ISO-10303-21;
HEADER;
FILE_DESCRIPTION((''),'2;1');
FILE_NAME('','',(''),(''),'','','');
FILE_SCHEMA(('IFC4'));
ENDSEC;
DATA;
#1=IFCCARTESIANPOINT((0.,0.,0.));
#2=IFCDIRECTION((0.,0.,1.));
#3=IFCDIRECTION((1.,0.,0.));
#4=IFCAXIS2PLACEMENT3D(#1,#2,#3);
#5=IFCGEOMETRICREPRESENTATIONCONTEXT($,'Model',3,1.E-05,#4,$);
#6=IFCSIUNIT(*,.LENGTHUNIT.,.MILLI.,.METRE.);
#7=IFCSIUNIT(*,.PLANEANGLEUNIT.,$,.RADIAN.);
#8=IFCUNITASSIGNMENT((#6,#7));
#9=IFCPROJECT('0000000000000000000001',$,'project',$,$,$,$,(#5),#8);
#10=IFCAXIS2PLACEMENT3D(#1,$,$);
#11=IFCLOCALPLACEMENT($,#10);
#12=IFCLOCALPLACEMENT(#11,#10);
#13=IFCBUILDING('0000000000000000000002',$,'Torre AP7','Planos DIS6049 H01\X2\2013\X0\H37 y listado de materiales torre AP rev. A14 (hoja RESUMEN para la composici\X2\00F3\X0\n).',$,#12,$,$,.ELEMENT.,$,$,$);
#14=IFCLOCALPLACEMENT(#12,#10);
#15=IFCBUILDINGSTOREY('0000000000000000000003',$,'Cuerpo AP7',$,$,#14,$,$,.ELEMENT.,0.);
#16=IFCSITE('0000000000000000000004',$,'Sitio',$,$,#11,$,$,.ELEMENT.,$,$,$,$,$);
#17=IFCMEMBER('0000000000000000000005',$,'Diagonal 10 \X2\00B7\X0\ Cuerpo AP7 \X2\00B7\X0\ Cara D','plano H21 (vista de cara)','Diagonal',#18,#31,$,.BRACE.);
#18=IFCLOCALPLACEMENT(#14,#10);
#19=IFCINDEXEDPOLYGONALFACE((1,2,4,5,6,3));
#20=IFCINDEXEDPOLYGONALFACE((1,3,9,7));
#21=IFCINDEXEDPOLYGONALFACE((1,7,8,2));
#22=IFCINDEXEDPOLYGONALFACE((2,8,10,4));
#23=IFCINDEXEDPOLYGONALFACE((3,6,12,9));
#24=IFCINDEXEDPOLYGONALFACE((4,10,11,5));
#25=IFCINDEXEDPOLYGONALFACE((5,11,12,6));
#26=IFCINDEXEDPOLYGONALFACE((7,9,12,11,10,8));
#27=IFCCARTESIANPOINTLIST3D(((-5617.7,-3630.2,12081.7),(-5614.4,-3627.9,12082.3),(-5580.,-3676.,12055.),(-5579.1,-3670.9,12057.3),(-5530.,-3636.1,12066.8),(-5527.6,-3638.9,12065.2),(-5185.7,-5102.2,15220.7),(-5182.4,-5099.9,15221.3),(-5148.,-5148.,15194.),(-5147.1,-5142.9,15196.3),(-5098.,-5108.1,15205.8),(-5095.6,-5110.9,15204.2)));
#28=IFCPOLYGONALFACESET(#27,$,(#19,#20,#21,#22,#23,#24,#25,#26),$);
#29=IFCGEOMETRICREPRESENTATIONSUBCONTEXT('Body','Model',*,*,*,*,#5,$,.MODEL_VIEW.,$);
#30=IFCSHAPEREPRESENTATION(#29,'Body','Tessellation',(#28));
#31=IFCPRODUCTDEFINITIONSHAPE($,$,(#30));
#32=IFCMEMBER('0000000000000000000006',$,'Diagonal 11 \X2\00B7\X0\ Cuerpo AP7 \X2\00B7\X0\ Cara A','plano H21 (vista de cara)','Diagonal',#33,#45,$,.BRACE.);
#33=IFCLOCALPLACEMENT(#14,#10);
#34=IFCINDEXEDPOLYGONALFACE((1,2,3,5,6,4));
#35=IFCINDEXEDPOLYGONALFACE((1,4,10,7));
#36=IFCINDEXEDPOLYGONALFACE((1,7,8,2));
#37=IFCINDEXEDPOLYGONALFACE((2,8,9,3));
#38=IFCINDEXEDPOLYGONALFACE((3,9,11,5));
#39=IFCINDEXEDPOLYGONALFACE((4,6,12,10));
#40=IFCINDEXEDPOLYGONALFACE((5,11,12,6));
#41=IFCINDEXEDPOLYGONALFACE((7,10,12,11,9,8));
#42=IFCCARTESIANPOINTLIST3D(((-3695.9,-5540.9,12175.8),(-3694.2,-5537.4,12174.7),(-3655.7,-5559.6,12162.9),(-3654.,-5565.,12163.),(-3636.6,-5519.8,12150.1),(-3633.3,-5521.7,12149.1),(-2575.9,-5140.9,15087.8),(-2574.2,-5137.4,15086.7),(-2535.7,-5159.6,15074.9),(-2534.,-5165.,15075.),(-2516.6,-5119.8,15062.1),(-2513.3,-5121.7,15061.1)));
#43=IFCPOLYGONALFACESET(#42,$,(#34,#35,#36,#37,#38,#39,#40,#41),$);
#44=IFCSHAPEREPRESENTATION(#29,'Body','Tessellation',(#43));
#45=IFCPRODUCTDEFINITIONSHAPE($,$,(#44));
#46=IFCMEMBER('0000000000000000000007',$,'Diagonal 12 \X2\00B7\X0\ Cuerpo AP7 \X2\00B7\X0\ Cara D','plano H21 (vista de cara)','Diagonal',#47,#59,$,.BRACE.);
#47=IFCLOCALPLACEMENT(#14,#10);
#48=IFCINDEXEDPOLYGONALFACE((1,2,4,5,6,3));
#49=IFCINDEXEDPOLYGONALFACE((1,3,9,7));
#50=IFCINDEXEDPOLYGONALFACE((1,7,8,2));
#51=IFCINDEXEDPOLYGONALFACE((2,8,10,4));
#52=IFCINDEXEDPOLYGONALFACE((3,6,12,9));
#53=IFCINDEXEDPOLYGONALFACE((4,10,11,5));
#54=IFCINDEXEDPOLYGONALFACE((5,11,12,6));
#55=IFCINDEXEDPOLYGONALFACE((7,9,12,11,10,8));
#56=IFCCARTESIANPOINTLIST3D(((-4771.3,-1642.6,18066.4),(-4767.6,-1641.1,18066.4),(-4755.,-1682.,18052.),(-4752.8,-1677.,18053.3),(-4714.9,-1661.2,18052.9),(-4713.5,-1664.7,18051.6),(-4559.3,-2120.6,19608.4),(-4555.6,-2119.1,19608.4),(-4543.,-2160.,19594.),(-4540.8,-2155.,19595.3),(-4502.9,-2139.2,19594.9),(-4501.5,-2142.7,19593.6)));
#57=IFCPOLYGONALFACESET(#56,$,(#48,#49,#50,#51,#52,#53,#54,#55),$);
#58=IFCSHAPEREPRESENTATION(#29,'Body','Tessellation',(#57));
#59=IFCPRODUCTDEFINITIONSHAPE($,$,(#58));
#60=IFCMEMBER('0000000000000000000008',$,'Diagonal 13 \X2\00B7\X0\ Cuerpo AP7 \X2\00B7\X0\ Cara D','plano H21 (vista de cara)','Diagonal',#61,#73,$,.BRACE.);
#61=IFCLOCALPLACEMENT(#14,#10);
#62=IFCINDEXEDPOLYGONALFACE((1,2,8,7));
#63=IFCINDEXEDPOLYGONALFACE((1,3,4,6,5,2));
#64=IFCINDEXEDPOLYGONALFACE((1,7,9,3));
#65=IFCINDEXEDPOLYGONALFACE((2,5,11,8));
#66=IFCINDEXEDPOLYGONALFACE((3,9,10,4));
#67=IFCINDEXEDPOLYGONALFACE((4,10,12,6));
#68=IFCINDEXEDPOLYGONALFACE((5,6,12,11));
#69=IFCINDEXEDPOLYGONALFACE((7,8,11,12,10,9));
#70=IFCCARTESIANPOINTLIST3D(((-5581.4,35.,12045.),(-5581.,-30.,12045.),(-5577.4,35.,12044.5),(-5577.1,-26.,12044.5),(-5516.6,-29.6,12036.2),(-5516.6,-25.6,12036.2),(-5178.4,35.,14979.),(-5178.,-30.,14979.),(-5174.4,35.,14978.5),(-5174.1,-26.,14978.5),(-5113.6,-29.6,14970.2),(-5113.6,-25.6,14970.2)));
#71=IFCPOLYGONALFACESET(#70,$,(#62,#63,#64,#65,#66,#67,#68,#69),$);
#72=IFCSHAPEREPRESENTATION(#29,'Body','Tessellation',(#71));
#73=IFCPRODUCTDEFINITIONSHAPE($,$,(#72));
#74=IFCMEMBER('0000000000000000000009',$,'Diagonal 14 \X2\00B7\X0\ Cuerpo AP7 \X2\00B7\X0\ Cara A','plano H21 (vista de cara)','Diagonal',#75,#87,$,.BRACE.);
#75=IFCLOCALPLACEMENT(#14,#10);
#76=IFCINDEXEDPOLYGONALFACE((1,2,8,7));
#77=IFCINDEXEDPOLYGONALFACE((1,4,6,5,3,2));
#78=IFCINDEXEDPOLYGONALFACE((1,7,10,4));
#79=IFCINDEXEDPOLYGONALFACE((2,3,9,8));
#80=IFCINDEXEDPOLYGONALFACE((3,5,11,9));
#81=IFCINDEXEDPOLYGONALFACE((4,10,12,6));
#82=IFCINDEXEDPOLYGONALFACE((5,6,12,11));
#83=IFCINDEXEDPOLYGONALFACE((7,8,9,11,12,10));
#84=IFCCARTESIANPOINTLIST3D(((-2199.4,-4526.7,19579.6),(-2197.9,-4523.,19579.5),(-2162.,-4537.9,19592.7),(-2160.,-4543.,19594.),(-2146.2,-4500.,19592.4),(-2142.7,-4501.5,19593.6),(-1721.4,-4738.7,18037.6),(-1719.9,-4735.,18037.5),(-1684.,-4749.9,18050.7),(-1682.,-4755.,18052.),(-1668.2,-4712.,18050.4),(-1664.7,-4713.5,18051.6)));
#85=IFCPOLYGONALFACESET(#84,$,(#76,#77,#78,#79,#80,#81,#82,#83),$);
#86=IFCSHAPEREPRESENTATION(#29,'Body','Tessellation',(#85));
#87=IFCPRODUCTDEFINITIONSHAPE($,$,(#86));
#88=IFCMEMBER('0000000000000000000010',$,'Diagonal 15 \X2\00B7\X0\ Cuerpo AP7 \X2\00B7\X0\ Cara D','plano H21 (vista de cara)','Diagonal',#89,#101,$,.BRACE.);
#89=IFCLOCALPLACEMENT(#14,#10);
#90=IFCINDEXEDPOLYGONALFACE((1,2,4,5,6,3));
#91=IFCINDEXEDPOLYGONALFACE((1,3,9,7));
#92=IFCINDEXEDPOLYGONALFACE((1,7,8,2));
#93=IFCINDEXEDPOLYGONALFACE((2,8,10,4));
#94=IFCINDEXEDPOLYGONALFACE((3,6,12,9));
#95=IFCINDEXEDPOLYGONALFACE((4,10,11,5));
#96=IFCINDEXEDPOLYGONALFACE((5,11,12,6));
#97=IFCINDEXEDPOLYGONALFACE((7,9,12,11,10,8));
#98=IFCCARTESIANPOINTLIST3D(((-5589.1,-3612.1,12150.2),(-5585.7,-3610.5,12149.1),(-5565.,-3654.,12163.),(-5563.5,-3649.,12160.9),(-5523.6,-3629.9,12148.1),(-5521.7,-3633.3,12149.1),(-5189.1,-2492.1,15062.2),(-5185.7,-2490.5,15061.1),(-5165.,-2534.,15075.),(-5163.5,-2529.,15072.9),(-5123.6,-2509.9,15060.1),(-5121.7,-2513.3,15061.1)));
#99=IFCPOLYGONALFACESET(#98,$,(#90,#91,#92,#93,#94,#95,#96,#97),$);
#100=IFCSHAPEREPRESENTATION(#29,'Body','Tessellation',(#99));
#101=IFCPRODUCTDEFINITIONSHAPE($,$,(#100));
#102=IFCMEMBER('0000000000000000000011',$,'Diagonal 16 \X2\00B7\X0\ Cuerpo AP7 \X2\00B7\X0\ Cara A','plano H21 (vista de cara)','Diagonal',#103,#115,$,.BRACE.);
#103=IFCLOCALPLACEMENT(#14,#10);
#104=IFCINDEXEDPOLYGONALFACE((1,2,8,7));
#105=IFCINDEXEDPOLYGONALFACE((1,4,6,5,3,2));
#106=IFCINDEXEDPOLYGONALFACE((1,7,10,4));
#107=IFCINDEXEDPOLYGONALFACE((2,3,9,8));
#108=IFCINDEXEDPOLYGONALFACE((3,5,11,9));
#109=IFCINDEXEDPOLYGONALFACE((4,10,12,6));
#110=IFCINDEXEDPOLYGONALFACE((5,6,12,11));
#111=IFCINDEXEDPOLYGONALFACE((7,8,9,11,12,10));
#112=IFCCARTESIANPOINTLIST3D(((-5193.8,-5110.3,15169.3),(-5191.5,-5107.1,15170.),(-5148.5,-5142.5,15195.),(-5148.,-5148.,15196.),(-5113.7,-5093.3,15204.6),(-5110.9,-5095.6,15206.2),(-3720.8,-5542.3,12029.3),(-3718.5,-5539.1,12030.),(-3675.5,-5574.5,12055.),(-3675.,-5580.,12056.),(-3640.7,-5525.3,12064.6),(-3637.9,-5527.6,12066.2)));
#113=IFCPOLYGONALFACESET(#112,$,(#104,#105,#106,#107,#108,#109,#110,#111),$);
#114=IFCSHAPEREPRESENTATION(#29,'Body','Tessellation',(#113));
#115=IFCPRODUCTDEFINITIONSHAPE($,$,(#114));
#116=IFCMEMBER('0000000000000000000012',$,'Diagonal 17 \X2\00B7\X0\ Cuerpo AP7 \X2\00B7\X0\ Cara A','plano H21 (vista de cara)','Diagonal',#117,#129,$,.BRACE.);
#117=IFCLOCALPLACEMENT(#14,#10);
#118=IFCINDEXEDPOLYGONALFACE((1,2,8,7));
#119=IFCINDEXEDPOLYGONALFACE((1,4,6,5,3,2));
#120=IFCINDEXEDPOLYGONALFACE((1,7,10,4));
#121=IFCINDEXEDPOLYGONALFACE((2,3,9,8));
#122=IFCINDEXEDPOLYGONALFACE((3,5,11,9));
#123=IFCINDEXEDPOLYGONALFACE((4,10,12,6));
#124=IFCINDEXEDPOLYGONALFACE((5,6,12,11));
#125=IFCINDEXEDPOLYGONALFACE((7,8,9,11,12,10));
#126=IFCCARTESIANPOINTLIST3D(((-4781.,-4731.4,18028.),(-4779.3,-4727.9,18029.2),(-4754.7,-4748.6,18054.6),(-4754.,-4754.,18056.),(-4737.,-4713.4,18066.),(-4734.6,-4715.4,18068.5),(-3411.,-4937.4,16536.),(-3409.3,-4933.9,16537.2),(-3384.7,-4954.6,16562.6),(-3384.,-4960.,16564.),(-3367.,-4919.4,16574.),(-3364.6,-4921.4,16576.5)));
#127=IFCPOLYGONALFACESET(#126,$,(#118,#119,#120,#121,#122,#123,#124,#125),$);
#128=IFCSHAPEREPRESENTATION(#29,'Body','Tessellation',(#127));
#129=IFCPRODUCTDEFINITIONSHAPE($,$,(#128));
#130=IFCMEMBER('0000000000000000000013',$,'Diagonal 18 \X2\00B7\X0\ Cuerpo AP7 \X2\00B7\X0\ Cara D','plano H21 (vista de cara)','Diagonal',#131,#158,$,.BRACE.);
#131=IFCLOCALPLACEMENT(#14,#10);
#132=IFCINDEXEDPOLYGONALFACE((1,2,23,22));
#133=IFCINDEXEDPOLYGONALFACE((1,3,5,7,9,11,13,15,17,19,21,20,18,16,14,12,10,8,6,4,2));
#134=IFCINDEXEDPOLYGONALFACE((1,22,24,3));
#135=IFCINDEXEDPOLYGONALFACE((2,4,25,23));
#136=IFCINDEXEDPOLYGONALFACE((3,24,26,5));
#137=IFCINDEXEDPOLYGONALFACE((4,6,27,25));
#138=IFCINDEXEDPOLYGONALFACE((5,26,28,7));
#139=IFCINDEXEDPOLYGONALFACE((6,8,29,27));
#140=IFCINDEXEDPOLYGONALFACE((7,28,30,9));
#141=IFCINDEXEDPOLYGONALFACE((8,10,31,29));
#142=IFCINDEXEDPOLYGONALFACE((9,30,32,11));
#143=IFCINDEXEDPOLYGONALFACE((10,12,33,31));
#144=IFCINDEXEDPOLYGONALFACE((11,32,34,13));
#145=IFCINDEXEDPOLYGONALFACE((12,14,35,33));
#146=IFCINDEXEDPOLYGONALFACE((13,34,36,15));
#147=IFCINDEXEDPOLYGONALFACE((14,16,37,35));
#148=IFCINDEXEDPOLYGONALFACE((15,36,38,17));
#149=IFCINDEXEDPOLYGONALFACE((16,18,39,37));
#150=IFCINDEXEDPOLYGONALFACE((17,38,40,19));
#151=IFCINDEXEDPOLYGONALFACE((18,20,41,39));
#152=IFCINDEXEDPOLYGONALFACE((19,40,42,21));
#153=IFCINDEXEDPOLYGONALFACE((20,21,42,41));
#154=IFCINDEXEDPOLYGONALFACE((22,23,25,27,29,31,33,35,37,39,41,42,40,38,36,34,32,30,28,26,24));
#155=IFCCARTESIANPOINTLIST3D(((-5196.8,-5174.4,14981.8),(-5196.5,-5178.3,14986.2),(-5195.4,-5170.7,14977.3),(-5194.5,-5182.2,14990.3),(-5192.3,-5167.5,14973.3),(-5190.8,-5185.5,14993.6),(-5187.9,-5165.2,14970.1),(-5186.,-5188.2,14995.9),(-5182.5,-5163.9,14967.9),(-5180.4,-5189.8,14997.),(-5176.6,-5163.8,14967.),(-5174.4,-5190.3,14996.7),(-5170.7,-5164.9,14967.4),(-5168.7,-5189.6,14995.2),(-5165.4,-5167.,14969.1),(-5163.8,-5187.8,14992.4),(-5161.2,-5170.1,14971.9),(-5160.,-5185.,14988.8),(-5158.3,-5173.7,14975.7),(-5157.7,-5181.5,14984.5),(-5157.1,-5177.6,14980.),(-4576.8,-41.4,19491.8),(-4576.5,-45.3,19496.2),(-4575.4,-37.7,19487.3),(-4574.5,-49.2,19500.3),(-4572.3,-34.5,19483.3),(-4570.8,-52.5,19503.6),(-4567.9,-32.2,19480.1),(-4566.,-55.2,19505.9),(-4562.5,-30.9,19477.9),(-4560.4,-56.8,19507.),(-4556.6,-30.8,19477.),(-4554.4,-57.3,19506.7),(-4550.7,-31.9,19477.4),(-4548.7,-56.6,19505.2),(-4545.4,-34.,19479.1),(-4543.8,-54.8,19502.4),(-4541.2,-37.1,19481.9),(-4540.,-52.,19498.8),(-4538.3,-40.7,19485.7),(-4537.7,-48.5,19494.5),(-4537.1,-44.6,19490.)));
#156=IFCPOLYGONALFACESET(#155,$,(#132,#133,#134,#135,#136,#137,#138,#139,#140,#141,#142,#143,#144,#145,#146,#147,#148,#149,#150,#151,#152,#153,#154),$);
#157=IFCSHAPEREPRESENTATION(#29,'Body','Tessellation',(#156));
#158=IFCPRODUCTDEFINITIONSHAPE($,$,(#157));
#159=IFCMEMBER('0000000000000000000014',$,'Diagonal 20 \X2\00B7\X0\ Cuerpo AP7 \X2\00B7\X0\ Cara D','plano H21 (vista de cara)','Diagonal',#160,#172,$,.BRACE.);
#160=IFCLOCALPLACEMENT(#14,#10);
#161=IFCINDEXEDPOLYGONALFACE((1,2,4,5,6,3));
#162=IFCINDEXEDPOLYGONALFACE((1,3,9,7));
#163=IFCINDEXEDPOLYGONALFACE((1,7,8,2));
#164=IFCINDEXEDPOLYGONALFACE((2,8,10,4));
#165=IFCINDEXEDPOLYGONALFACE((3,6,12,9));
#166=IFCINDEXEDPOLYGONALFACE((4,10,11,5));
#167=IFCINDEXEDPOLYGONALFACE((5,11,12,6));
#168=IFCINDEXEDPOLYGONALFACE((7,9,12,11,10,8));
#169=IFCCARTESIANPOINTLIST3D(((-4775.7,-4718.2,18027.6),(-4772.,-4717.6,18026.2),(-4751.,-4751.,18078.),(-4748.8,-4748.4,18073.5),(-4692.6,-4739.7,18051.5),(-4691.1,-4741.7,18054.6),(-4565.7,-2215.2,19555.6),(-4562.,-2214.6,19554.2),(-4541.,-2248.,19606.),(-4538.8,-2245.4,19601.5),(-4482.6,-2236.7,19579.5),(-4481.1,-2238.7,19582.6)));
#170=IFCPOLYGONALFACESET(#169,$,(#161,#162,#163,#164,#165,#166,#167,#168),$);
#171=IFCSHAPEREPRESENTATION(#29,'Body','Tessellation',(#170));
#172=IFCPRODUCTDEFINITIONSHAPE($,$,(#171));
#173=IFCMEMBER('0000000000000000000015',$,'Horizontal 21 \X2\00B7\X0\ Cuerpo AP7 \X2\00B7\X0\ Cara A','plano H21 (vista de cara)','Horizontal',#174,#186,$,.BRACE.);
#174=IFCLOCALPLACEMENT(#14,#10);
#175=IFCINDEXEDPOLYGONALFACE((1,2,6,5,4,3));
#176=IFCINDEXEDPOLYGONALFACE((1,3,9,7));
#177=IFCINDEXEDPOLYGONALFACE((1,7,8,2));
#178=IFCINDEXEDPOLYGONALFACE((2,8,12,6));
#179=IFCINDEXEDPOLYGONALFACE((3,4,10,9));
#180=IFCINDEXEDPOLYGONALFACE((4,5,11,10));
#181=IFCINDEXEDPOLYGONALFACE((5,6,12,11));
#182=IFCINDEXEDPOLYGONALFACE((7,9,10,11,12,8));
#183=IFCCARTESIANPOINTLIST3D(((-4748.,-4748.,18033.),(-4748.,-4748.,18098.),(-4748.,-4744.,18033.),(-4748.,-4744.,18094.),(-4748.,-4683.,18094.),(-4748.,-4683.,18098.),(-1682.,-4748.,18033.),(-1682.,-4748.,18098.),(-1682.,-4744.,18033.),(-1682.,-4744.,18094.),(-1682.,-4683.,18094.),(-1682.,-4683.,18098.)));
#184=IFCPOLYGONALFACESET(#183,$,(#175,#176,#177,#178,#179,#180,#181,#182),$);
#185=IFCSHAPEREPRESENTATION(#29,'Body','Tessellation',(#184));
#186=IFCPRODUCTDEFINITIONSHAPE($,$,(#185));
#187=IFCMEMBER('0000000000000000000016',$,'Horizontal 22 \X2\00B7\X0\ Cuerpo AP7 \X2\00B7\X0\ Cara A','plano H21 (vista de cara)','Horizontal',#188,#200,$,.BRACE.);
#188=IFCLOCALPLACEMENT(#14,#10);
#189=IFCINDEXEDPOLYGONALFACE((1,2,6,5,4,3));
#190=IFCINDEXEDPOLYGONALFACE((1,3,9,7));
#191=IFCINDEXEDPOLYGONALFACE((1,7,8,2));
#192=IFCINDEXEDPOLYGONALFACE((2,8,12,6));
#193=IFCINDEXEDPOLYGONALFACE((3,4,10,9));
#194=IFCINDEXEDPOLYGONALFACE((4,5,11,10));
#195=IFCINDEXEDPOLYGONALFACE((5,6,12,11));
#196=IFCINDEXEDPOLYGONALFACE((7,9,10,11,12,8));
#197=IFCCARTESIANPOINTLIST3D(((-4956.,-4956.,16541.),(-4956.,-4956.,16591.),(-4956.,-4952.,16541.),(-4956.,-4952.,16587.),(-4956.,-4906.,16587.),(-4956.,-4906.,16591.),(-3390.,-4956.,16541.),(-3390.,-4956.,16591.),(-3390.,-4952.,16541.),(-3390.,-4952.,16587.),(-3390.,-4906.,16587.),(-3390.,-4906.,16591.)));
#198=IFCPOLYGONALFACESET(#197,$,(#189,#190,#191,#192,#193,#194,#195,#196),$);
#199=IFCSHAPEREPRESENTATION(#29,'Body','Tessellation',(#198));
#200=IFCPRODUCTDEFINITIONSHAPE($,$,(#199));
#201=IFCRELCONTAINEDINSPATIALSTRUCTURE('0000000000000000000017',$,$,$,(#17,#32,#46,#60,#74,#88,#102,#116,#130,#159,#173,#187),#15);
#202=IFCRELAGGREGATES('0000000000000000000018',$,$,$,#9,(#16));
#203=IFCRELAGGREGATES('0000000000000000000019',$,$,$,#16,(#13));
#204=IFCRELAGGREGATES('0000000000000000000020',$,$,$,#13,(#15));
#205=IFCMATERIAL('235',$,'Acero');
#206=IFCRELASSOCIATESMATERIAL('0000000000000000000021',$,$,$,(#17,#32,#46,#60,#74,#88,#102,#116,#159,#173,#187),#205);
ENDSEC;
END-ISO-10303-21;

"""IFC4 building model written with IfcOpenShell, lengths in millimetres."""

from ifc_helpers import new_model, si_unit, frame, frame_2d, origin, origin_with_axes, place, context, subcontext, project, spatial, circle, l_section, extrude, material, element, save


model = new_model("IFC4")

# Units and contexts
model_context = context("Model", 3, precision=1e-05, world=origin_with_axes())
body_context = subcontext(model_context, "Body", "Model", "MODEL_VIEW")
ifc_project = project(units=[si_unit("LENGTHUNIT", "METRE", prefix="MILLI"), si_unit("PLANEANGLEUNIT", "RADIAN")], contexts=[model_context])

# Site, building, storey
site_placement = place(None, origin())
site = spatial("IfcSite", under=ifc_project, at=site_placement, Name="Sitio", CompositionType="ELEMENT")
building_placement = place(site_placement, origin())
building = spatial("IfcBuilding", under=site, at=building_placement, Name="Torre AP7", Description="Planos DIS6049 H01–H37 y listado de materiales torre AP rev. A14 (hoja RESUMEN para la composición).", CompositionType="ELEMENT")
storey_placement = place(building_placement, origin())
storey = spatial("IfcBuildingStorey", under=building, at=storey_placement, Name="Cuerpo AP7", CompositionType="ELEMENT", Elevation=0.0)

# Members
ifc_material_1 = material(Name="235", Category="Acero")
member_1_placement = place(storey_placement, frame((-5580.0, -3676.0, 12055.0), z_axis=(0.123647, -0.421316, 0.898445), x_axis=(0.805624, 0.571243, 0.157006)))
element("IfcMember", 1, at=member_1_placement, inside=storey, material=ifc_material_1, Name="Diagonal 10 · Cuerpo AP7 · Cara D", Description="plano H21 (vista de cara)", ObjectType="Diagonal", PredefinedType="BRACE", context=body_context, shape_type="SweptSolid", body=[
    extrude(l_section(Depth=65.0, Width=65.0, Thickness=4.0, at=frame_2d((32.5, 32.5))), None, (0.0, 0.0, 1.0), 3493.8),
])
member_2_placement = place(storey_placement, frame((-3654.0, -5565.0, 12163.0), z_axis=(0.356065, 0.127166, 0.925768), x_axis=(0.414588, 0.866358, -0.278462)))
element("IfcMember", 2, at=member_2_placement, inside=storey, material=ifc_material_1, Name="Diagonal 11 · Cuerpo AP7 · Cara A", Description="plano H21 (vista de cara)", ObjectType="Diagonal", PredefinedType="BRACE", context=body_context, shape_type="SweptSolid", body=[
    extrude(l_section(Depth=50.0, Width=50.0, Thickness=4.0, at=frame_2d((25.0, 25.0))), None, (0.0, 0.0, 1.0), 3145.5),
])
member_3_placement = place(storey_placement, frame((-4755.0, -1682.0, 18052.0), z_axis=(0.130201, -0.293567, 0.94703), x_axis=(0.923169, 0.384316, -0.007788)))
element("IfcMember", 3, at=member_3_placement, inside=storey, material=ifc_material_1, Name="Diagonal 12 · Cuerpo AP7 · Cara D", Description="plano H21 (vista de cara)", ObjectType="Diagonal", PredefinedType="BRACE", context=body_context, shape_type="SweptSolid", body=[
    extrude(l_section(Depth=45.0, Width=45.0, Thickness=4.0, at=frame_2d((22.5, 22.5))), None, (0.0, 0.0, 1.0), 1628.2),
])
member_4_placement = place(storey_placement, frame((-5581.0, -30.0, 12045.0), z_axis=(0.136077, 0.0, 0.990698), x_axis=(0.990683, 0.005629, -0.136075)))
element("IfcMember", 4, at=member_4_placement, inside=storey, material=ifc_material_1, Name="Diagonal 13 · Cuerpo AP7 · Cara D", Description="plano H21 (vista de cara)", ObjectType="Diagonal", PredefinedType="BRACE", context=body_context, shape_type="SweptSolid", body=[
    extrude(l_section(Depth=65.0, Width=65.0, Thickness=4.0, at=frame_2d((32.5, 32.5))), None, (0.0, 0.0, 1.0), 2961.5),
])
member_5_placement = place(storey_placement, frame((-1682.0, -4755.0, 18052.0), z_axis=(-0.293567, 0.130201, 0.94703), x_axis=(0.384316, 0.923169, -0.007788)))
element("IfcMember", 5, at=member_5_placement, inside=storey, material=ifc_material_1, Name="Diagonal 14 · Cuerpo AP7 · Cara A", Description="plano H21 (vista de cara)", ObjectType="Diagonal", PredefinedType="BRACE", context=body_context, shape_type="SweptSolid", body=[
    extrude(l_section(Depth=45.0, Width=45.0, Thickness=4.0, at=frame_2d((22.5, 22.5))), None, (0.0, 0.0, 1.0), 1628.2),
])
member_6_placement = place(storey_placement, frame((-5565.0, -3654.0, 12163.0), z_axis=(0.127166, 0.356065, 0.925768), x_axis=(0.866358, 0.414588, -0.278462)))
element("IfcMember", 6, at=member_6_placement, inside=storey, material=ifc_material_1, Name="Diagonal 15 · Cuerpo AP7 · Cara D", Description="plano H21 (vista de cara)", ObjectType="Diagonal", PredefinedType="BRACE", context=body_context, shape_type="SweptSolid", body=[
    extrude(l_section(Depth=50.0, Width=50.0, Thickness=4.0, at=frame_2d((25.0, 25.0))), None, (0.0, 0.0, 1.0), 3145.5),
])
member_7_placement = place(storey_placement, frame((-3675.0, -5580.0, 12056.0), z_axis=(-0.421443, 0.1236, 0.898392), x_axis=(0.571147, 0.805677, 0.157085)))
element("IfcMember", 7, at=member_7_placement, inside=storey, material=ifc_material_1, Name="Diagonal 16 · Cuerpo AP7 · Cara A", Description="plano H21 (vista de cara)", ObjectType="Diagonal", PredefinedType="BRACE", context=body_context, shape_type="SweptSolid", body=[
    extrude(l_section(Depth=65.0, Width=65.0, Thickness=4.0, at=frame_2d((32.5, 32.5))), None, (0.0, 0.0, 1.0), 3495.1),
])
member_8_placement = place(storey_placement, frame((-3384.0, -4960.0, 16564.0), z_axis=(-0.67288, 0.101178, 0.7328), x_axis=(0.431654, 0.858174, 0.27787)))
element("IfcMember", 8, at=member_8_placement, inside=storey, material=ifc_material_1, Name="Diagonal 17 · Cuerpo AP7 · Cara A", Description="plano H21 (vista de cara)", ObjectType="Diagonal", PredefinedType="BRACE", context=body_context, shape_type="SweptSolid", body=[
    extrude(l_section(Depth=45.0, Width=45.0, Thickness=4.0, at=frame_2d((22.5, 22.5))), None, (0.0, 0.0, 1.0), 2036.0),
])
member_9_placement = place(storey_placement, frame((-5177.0, -5177.0, 14982.0), z_axis=(0.090367, 0.748151, 0.657346), x_axis=(0.934337, 0.164794, -0.316003)))
element("IfcMember", 9, at=member_9_placement, inside=storey, Name="Diagonal 18 · Cuerpo AP7 · Cara D", Description="plano H21 (vista de cara)", ObjectType="Diagonal", PredefinedType="BRACE", context=body_context, shape_type="SweptSolid", body=[
    extrude(circle(Radius=20.0), None, (0.0, 0.0, 1.0), 6860.9),
])
member_10_placement = place(storey_placement, frame((-4751.0, -4751.0, 18078.0), z_axis=(0.071427, 0.851346, 0.519719), x_axis=(0.922089, 0.142318, -0.359857)))
element("IfcMember", 10, at=member_10_placement, inside=storey, material=ifc_material_1, Name="Diagonal 20 · Cuerpo AP7 · Cara D", Description="plano H21 (vista de cara)", ObjectType="Diagonal", PredefinedType="BRACE", context=body_context, shape_type="SweptSolid", body=[
    extrude(l_section(Depth=65.0, Width=65.0, Thickness=4.0, at=frame_2d((32.5, 32.5))), None, (0.0, 0.0, 1.0), 2940.0),
])
member_11_placement = place(storey_placement, frame((-1682.0, -4748.0, 18098.0), z_axis=(-1.0, 0.0, 0.0), x_axis=(0.0, 1.0, 0.0)))
element("IfcMember", 11, at=member_11_placement, inside=storey, material=ifc_material_1, Name="Horizontal 21 · Cuerpo AP7 · Cara A", Description="plano H21 (vista de cara)", ObjectType="Horizontal", PredefinedType="BRACE", context=body_context, shape_type="SweptSolid", body=[
    extrude(l_section(Depth=65.0, Width=65.0, Thickness=4.0, at=frame_2d((32.5, 32.5))), None, (0.0, 0.0, 1.0), 3066.0),
])
member_12_placement = place(storey_placement, frame((-3390.0, -4956.0, 16591.0), z_axis=(-1.0, 0.0, 0.0), x_axis=(0.0, 1.0, 0.0)))
element("IfcMember", 12, at=member_12_placement, inside=storey, material=ifc_material_1, Name="Horizontal 22 · Cuerpo AP7 · Cara A", Description="plano H21 (vista de cara)", ObjectType="Horizontal", PredefinedType="BRACE", context=body_context, shape_type="SweptSolid", body=[
    extrude(l_section(Depth=50.0, Width=50.0, Thickness=4.0, at=frame_2d((25.0, 25.0))), None, (0.0, 0.0, 1.0), 1566.0),
])

save(model, "model.ifc")
